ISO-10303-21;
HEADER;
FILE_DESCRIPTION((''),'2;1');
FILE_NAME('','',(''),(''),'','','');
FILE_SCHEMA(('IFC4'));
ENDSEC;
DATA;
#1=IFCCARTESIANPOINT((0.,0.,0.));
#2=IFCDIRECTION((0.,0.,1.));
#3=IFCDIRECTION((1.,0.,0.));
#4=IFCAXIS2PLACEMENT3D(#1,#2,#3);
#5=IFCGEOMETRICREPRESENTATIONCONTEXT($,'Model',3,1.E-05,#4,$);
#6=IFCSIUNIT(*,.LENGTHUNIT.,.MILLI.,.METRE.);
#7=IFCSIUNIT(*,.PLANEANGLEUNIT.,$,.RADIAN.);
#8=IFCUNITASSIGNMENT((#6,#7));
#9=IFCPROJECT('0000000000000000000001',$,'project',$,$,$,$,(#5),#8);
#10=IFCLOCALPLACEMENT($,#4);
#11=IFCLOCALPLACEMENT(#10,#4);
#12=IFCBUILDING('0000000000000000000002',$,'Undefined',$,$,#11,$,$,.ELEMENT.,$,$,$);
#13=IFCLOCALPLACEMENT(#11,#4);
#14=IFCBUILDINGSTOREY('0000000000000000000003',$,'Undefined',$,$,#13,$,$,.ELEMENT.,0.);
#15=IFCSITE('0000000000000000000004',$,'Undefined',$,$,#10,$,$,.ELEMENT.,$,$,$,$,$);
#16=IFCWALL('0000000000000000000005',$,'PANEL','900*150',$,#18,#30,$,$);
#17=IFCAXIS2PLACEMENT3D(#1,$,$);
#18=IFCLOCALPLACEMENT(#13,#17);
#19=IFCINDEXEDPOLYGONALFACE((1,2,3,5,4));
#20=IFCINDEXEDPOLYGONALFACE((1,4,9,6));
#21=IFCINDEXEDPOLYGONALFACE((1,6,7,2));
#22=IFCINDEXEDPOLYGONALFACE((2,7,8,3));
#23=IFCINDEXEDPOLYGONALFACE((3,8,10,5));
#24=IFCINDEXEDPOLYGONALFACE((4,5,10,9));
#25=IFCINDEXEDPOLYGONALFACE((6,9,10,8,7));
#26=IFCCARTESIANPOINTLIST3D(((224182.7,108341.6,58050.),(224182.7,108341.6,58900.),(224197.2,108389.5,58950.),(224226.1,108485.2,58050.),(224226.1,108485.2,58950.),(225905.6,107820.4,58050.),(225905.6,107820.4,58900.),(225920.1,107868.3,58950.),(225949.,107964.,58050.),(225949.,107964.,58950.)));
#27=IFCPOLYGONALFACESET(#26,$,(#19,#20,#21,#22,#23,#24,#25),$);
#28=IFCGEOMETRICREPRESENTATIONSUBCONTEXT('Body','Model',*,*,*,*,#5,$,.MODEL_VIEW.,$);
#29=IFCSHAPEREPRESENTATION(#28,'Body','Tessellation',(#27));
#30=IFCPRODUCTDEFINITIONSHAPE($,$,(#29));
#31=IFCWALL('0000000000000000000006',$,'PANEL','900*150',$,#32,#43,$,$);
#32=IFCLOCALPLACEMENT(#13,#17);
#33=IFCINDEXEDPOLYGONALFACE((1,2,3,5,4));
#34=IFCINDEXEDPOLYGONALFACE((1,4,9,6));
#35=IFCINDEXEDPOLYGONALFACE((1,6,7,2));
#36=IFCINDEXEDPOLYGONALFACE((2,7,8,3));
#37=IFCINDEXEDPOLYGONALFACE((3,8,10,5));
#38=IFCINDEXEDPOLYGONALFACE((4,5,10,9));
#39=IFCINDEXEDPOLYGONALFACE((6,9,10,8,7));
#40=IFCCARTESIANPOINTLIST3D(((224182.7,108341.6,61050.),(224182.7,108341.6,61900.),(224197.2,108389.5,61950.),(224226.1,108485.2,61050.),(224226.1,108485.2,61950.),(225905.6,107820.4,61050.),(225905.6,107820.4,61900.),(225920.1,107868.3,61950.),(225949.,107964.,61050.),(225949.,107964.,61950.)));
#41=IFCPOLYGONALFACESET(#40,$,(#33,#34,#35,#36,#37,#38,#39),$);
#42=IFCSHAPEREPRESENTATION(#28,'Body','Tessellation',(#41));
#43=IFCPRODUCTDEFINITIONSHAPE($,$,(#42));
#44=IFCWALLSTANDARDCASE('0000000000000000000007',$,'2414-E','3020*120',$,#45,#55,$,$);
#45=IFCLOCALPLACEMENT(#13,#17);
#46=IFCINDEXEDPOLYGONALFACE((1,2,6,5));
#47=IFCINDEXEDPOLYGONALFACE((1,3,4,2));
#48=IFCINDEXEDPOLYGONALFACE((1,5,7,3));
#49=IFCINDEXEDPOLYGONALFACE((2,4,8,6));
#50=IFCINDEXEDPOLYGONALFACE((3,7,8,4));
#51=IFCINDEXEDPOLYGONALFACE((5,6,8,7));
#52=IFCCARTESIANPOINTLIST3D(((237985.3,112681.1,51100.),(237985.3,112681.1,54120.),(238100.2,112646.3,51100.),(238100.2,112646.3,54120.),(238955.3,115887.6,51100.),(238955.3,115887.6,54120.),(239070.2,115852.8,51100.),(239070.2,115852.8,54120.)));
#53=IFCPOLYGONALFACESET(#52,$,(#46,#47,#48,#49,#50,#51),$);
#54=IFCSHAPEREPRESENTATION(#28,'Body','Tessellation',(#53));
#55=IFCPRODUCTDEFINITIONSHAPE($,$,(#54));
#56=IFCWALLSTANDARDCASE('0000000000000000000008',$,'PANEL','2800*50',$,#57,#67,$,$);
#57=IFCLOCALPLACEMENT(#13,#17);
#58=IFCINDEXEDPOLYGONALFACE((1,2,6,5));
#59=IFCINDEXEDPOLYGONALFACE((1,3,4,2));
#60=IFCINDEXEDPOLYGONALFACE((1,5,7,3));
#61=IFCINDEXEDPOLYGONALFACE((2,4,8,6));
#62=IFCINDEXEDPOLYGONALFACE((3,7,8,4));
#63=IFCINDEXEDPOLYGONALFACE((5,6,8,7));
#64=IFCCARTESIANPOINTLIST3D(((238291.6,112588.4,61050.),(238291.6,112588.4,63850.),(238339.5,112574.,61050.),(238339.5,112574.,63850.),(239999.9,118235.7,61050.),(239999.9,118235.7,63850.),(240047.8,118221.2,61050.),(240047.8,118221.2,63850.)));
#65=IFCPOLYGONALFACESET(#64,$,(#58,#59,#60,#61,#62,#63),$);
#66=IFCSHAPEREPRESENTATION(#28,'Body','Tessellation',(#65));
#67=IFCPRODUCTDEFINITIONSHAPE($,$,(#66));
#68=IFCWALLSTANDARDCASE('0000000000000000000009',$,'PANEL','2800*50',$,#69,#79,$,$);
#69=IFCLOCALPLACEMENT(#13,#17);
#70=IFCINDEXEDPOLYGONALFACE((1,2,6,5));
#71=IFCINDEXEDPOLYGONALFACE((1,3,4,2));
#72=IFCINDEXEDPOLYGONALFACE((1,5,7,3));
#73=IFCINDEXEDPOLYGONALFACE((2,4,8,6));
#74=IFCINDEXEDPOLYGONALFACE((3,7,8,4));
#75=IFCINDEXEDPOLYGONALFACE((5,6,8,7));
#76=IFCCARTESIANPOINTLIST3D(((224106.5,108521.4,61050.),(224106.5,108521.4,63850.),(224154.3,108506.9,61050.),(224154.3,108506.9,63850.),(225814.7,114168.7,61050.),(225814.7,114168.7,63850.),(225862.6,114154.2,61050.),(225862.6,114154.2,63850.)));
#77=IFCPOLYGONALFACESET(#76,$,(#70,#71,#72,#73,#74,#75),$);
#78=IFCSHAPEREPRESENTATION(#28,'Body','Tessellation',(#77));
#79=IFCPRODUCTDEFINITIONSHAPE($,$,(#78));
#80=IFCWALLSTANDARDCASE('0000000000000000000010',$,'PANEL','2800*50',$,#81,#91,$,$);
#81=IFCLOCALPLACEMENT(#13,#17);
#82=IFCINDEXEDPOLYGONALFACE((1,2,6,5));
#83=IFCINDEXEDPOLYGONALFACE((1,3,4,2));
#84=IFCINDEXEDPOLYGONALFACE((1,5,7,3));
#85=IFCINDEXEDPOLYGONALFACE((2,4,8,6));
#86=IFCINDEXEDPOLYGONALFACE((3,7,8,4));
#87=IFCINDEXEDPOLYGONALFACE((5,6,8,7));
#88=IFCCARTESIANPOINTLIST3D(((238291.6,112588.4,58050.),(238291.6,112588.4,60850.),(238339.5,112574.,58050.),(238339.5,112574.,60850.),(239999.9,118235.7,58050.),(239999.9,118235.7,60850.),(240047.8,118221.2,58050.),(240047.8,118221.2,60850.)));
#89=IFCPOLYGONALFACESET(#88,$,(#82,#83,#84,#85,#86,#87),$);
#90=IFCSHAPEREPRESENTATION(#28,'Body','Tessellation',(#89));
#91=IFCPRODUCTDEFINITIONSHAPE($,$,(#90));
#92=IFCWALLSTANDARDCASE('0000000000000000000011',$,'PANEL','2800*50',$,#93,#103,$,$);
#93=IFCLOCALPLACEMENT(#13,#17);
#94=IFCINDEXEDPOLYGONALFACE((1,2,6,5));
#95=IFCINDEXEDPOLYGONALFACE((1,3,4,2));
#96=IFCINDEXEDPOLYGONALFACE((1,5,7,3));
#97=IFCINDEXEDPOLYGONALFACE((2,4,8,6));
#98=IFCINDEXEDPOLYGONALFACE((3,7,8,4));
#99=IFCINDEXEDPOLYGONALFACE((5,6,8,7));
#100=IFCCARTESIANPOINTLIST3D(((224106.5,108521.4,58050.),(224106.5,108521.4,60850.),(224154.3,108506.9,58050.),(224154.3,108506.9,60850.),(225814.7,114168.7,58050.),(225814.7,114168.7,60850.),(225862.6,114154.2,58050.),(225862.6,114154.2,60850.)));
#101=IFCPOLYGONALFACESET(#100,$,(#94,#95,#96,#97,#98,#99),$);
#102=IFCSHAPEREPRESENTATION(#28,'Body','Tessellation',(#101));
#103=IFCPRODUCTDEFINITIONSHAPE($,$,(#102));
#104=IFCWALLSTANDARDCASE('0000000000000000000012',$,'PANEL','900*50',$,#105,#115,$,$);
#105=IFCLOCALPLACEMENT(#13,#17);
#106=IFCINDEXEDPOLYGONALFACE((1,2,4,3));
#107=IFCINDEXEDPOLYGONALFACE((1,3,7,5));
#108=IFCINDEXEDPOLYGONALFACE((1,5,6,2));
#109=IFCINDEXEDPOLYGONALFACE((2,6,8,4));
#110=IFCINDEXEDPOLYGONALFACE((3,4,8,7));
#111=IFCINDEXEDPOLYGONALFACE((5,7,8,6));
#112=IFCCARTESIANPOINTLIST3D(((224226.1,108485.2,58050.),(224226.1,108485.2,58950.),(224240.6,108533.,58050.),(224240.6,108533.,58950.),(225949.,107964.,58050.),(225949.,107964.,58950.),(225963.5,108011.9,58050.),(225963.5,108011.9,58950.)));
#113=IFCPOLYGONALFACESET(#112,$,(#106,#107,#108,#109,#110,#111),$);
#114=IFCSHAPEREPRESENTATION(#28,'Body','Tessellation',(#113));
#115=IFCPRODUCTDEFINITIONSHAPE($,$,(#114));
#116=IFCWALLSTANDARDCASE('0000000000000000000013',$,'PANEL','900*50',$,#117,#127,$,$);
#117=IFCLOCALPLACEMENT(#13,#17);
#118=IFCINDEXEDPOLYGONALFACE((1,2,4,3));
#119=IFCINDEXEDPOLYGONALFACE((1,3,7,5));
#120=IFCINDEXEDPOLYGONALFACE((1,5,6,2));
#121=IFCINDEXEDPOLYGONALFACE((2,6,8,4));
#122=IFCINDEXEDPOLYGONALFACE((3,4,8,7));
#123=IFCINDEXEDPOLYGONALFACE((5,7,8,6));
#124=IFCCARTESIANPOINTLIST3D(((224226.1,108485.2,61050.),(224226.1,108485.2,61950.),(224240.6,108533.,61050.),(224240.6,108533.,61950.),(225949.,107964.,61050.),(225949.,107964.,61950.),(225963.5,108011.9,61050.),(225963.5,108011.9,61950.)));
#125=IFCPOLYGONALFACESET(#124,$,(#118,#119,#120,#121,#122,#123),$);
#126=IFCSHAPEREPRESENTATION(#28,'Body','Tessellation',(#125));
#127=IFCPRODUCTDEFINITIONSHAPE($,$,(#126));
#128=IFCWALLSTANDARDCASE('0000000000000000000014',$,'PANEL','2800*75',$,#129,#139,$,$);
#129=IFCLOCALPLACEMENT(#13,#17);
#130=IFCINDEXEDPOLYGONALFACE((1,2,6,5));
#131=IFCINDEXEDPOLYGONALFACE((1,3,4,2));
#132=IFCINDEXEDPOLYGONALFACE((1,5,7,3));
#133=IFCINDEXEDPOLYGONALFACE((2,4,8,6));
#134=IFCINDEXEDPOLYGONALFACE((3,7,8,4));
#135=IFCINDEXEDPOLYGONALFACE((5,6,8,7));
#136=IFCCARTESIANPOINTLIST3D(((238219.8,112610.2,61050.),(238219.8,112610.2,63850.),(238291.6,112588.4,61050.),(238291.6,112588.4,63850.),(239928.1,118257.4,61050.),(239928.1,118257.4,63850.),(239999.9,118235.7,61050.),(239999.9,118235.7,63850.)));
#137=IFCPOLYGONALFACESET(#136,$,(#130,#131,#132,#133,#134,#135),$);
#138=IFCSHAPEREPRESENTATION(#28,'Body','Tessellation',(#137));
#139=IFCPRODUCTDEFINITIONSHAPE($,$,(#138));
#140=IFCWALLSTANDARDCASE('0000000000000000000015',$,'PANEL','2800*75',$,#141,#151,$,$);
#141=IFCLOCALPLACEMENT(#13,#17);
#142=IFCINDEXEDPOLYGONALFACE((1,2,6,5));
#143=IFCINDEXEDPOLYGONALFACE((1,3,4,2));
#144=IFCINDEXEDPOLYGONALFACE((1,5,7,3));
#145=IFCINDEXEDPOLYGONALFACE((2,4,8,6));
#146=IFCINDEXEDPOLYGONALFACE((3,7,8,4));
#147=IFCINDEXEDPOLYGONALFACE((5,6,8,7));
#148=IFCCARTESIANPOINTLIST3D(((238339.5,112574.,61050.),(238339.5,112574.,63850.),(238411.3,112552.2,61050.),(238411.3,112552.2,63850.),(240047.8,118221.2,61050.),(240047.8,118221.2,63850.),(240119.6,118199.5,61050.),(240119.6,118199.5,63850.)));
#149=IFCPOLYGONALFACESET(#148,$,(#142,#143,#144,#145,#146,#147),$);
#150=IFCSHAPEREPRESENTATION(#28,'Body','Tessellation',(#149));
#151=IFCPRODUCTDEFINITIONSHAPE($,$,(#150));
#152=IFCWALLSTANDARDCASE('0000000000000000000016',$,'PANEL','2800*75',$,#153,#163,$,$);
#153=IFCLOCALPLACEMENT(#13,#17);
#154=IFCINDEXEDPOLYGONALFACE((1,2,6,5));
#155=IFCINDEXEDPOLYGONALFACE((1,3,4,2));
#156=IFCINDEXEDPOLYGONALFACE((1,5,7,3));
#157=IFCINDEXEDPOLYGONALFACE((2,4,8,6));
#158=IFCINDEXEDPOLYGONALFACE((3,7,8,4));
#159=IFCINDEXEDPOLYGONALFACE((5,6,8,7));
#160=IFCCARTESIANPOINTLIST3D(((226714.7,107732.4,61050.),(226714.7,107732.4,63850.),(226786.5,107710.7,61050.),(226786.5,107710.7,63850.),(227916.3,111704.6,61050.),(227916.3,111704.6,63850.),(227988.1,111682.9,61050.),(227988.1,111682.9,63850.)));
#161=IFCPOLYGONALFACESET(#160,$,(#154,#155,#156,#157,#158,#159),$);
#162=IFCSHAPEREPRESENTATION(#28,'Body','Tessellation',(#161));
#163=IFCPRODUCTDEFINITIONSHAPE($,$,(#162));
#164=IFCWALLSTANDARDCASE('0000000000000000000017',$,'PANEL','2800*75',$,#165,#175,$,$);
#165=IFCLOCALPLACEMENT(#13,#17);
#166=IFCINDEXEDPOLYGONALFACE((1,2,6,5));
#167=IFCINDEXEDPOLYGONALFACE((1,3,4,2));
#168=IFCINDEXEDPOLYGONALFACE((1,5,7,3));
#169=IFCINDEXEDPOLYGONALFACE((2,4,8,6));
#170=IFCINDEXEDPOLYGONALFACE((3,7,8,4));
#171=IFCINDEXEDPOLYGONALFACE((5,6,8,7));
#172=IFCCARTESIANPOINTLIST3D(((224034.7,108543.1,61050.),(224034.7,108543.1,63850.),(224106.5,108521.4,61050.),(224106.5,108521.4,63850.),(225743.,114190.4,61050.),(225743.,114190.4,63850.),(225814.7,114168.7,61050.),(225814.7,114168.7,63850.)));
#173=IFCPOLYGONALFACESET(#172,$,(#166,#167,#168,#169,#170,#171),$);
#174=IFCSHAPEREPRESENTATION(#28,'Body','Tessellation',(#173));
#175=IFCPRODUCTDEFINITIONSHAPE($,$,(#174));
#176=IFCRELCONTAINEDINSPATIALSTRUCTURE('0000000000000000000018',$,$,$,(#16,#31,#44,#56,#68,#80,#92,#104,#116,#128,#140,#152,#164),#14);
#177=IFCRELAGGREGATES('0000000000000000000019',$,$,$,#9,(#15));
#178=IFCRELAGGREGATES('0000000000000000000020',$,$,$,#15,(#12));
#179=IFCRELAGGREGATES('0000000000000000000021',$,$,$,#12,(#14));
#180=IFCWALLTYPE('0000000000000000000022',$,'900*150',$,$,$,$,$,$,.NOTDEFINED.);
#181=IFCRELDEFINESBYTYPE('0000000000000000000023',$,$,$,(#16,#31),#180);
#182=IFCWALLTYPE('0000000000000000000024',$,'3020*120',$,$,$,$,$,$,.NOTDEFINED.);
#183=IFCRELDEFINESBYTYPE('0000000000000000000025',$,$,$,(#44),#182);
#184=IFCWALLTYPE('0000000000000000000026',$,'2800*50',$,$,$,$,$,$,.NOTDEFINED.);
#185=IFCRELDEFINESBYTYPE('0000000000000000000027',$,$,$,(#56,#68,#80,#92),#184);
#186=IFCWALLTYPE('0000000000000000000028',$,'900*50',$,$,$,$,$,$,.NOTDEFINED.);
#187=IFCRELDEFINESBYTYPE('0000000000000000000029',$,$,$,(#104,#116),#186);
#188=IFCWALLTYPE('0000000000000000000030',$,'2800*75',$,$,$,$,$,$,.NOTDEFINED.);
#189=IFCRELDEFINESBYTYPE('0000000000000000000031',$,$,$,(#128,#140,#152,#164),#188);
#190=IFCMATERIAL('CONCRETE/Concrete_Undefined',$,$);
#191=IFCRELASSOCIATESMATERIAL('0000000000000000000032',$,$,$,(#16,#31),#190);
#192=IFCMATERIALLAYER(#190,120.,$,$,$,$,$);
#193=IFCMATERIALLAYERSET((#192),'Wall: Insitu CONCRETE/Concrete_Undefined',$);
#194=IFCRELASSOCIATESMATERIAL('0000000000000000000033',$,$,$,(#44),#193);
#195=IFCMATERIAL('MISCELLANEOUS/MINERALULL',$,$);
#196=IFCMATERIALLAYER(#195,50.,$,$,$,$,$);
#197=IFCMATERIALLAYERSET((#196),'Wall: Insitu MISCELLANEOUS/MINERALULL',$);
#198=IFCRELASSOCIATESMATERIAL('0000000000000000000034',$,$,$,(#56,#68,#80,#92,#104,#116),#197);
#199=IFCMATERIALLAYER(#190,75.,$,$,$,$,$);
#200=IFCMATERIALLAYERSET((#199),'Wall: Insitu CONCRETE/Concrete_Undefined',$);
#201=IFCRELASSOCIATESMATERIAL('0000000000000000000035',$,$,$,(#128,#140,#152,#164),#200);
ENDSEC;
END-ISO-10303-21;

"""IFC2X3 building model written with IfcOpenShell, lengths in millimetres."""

from ifc_helpers import new_model, si_unit, frame, frame_2d, origin_with_axes, place, context, subcontext, project, spatial, rectangle, extrude, clip, halfspace, material, layer, layer_set, layer_usage, type_object, element, save


model = new_model("IFC2X3")

# Units and contexts
model_context = context("Model", 3, precision=1e-05, world=origin_with_axes())
body_context = subcontext(model_context, "Body", "Model", "MODEL_VIEW")
ifc_project = project(units=[si_unit("LENGTHUNIT", "METRE", prefix="MILLI"), si_unit("PLANEANGLEUNIT", "RADIAN")], contexts=[model_context])

# Site, building, storey
site_placement = place(None, origin_with_axes())
site = spatial("IfcSite", under=ifc_project, at=site_placement, Name="Undefined", CompositionType="ELEMENT")
building_placement = place(site_placement, origin_with_axes())
building = spatial("IfcBuilding", under=site, at=building_placement, Name="Undefined", CompositionType="ELEMENT")
storey_placement = place(building_placement, origin_with_axes())
storey = spatial("IfcBuildingStorey", under=building, at=storey_placement, Name="Undefined", CompositionType="ELEMENT", Elevation=0.0)

# Shared definitions
ifc_material_1 = material(Name="CONCRETE/Concrete_Undefined")

# Walls
wall_type_1 = type_object("IfcWallType", Name="900*150", PredefinedType="NOTDEFINED")
for number, where, z_axis, x_axis, name in (
    (1, (224204.4, 108413.4, 58050.0), (0.0, 0.0, 1.0), (0.957166, -0.289541, 0.0), "PANEL"),
    (2, (224204.4, 108413.4, 61050.0), (0.0, 0.0, 1.0), (0.957166, -0.289541, 0.0), "PANEL"),
):
    element("IfcWall", number, at=place(storey_placement, frame(where, z_axis=z_axis, x_axis=x_axis)), inside=storey, type_object=wall_type_1, material=ifc_material_1, Name=name, Description="900*150", context=body_context, shape_type="Clipping", body=[
        clip(extrude(rectangle(XDim=1800.0, YDim=150.0, at=frame_2d((0.0, 900.0), x_axis=(0.0, -1.0))), frame((0.0, 0.0, 0.0), z_axis=(0.0, 0.0, 1.0), x_axis=(0.0, -1.0, 0.0)), (0.0, 0.0, 1.0), 900.0), halfspace(frame((2400.0, 75.0, 1000.0), z_axis=(0.000001, -0.707072, 0.707141), x_axis=(0.0, -0.707141, -0.707072)), False)),
    ])
ifc_layer_1 = layer(ifc_material_1, 120.0)
ifc_layer_set_1 = layer_set([ifc_layer_1], Name="Wall: Insitu CONCRETE/Concrete_Undefined")
ifc_layer_usage_1 = layer_usage(ifc_layer_set_1, "AXIS2", "POSITIVE", -60.0)
wall_type_2 = type_object("IfcWallType", Name="3020*120", PredefinedType="NOTDEFINED")
wall_1_placement = place(storey_placement, frame((238042.8, 112663.7, 51100.0), z_axis=(0.0, 0.0, 1.0), x_axis=(0.289539, 0.957166, 0.0)))
element("IfcWallStandardCase", 3, at=wall_1_placement, inside=storey, type_object=wall_type_2, material=ifc_layer_usage_1, Name="2414-E", Description="3020*120", context=body_context, shape_type="SweptSolid", body=[
    extrude(rectangle(XDim=3350.0, YDim=120.0, at=frame_2d((0.0, 1675.0), x_axis=(0.0, -1.0))), frame((0.0, 0.0, 0.0), z_axis=(0.0, 0.0, 1.0), x_axis=(0.0, -1.0, 0.0)), (0.0, 0.0, 1.0), 3020.0),
])
ifc_material_2 = material(Name="MISCELLANEOUS/MINERALULL")
ifc_layer_2 = layer(ifc_material_2, 50.0)
ifc_layer_set_2 = layer_set([ifc_layer_2], Name="Wall: Insitu MISCELLANEOUS/MINERALULL")
ifc_layer_usage_2 = layer_usage(ifc_layer_set_2, "AXIS2", "POSITIVE", -25.0)
wall_type_3 = type_object("IfcWallType", Name="2800*50", PredefinedType="NOTDEFINED")
wall_2_placement = place(storey_placement, frame((238315.6, 112581.2, 61050.0), z_axis=(0.0, 0.0, 1.0), x_axis=(0.289537, 0.957167, 0.0)))
element("IfcWallStandardCase", 4, at=wall_2_placement, inside=storey, type_object=wall_type_3, material=ifc_layer_usage_2, Name="PANEL", Description="2800*50", context=body_context, shape_type="SweptSolid", body=[
    extrude(rectangle(XDim=5900.0, YDim=50.0, at=frame_2d((0.0, 2950.0), x_axis=(0.0, -1.0))), frame((0.0, 0.0, 0.0), z_axis=(0.0, 0.0, 1.0), x_axis=(0.0, -1.0, 0.0)), (0.0, 0.0, 1.0), 2800.0),
])
ifc_layer_usage_3 = layer_usage(ifc_layer_set_2, "AXIS2", "POSITIVE", -25.0)
wall_3_placement = place(storey_placement, frame((224130.4, 108514.1, 61050.0), z_axis=(0.0, 0.0, 1.0), x_axis=(0.289538, 0.957166, 0.0)))
element("IfcWallStandardCase", 5, at=wall_3_placement, inside=storey, type_object=wall_type_3, material=ifc_layer_usage_3, Name="PANEL", Description="2800*50", context=body_context, shape_type="SweptSolid", body=[
    extrude(rectangle(XDim=5900.0, YDim=50.0, at=frame_2d((0.0, 2950.0), x_axis=(0.0, -1.0))), frame((0.0, 0.0, 0.0), z_axis=(0.0, 0.0, 1.0), x_axis=(0.0, -1.0, 0.0)), (0.0, 0.0, 1.0), 2800.0),
])
ifc_layer_usage_4 = layer_usage(ifc_layer_set_2, "AXIS2", "POSITIVE", -25.0)
wall_4_placement = place(storey_placement, frame((238315.6, 112581.2, 58050.0), z_axis=(0.0, 0.0, 1.0), x_axis=(0.289537, 0.957167, 0.0)))
element("IfcWallStandardCase", 6, at=wall_4_placement, inside=storey, type_object=wall_type_3, material=ifc_layer_usage_4, Name="PANEL", Description="2800*50", context=body_context, shape_type="SweptSolid", body=[
    extrude(rectangle(XDim=5900.0, YDim=50.0, at=frame_2d((0.0, 2950.0), x_axis=(0.0, -1.0))), frame((0.0, 0.0, 0.0), z_axis=(0.0, 0.0, 1.0), x_axis=(0.0, -1.0, 0.0)), (0.0, 0.0, 1.0), 2800.0),
])
ifc_layer_usage_5 = layer_usage(ifc_layer_set_2, "AXIS2", "POSITIVE", -25.0)
wall_5_placement = place(storey_placement, frame((224130.4, 108514.1, 58050.0), z_axis=(0.0, 0.0, 1.0), x_axis=(0.289538, 0.957166, 0.0)))
element("IfcWallStandardCase", 7, at=wall_5_placement, inside=storey, type_object=wall_type_3, material=ifc_layer_usage_5, Name="PANEL", Description="2800*50", context=body_context, shape_type="SweptSolid", body=[
    extrude(rectangle(XDim=5900.0, YDim=50.0, at=frame_2d((0.0, 2950.0), x_axis=(0.0, -1.0))), frame((0.0, 0.0, 0.0), z_axis=(0.0, 0.0, 1.0), x_axis=(0.0, -1.0, 0.0)), (0.0, 0.0, 1.0), 2800.0),
])
ifc_layer_usage_6 = layer_usage(ifc_layer_set_2, "AXIS2", "POSITIVE", -25.0)
wall_type_4 = type_object("IfcWallType", Name="900*50", PredefinedType="NOTDEFINED")
wall_6_placement = place(storey_placement, frame((224233.4, 108509.1, 58050.0), z_axis=(0.0, 0.0, 1.0), x_axis=(0.957166, -0.289541, 0.0)))
element("IfcWallStandardCase", 8, at=wall_6_placement, inside=storey, type_object=wall_type_4, material=ifc_layer_usage_6, Name="PANEL", Description="900*50", context=body_context, shape_type="SweptSolid", body=[
    extrude(rectangle(XDim=1800.0, YDim=50.0, at=frame_2d((0.0, 900.0), x_axis=(0.0, -1.0))), frame((0.0, 0.0, 0.0), z_axis=(0.0, 0.0, 1.0), x_axis=(0.0, -1.0, 0.0)), (0.0, 0.0, 1.0), 900.0),
])
ifc_layer_usage_7 = layer_usage(ifc_layer_set_2, "AXIS2", "POSITIVE", -25.0)
wall_7_placement = place(storey_placement, frame((224233.4, 108509.1, 61050.0), z_axis=(0.0, 0.0, 1.0), x_axis=(0.957166, -0.289541, 0.0)))
element("IfcWallStandardCase", 9, at=wall_7_placement, inside=storey, type_object=wall_type_4, material=ifc_layer_usage_7, Name="PANEL", Description="900*50", context=body_context, shape_type="SweptSolid", body=[
    extrude(rectangle(XDim=1800.0, YDim=50.0, at=frame_2d((0.0, 900.0), x_axis=(0.0, -1.0))), frame((0.0, 0.0, 0.0), z_axis=(0.0, 0.0, 1.0), x_axis=(0.0, -1.0, 0.0)), (0.0, 0.0, 1.0), 900.0),
])
ifc_layer_3 = layer(ifc_material_1, 75.0)
ifc_layer_set_3 = layer_set([ifc_layer_3], Name="Wall: Insitu CONCRETE/Concrete_Undefined")
ifc_layer_usage_8 = layer_usage(ifc_layer_set_3, "AXIS2", "POSITIVE", -37.5)
wall_type_5 = type_object("IfcWallType", Name="2800*75", PredefinedType="NOTDEFINED")
wall_8_placement = place(storey_placement, frame((238255.7, 112599.3, 61050.0), z_axis=(0.0, 0.0, 1.0), x_axis=(0.289537, 0.957167, 0.0)))
element("IfcWallStandardCase", 10, at=wall_8_placement, inside=storey, type_object=wall_type_5, material=ifc_layer_usage_8, Name="PANEL", Description="2800*75", context=body_context, shape_type="SweptSolid", body=[
    extrude(rectangle(XDim=5900.0, YDim=75.0, at=frame_2d((0.0, 2950.0), x_axis=(0.0, -1.0))), frame((0.0, 0.0, 0.0), z_axis=(0.0, 0.0, 1.0), x_axis=(0.0, -1.0, 0.0)), (0.0, 0.0, 1.0), 2800.0),
])
ifc_layer_usage_9 = layer_usage(ifc_layer_set_3, "AXIS2", "POSITIVE", -37.5)
wall_9_placement = place(storey_placement, frame((238375.4, 112563.1, 61050.0), z_axis=(0.0, 0.0, 1.0), x_axis=(0.289537, 0.957167, 0.0)))
element("IfcWallStandardCase", 11, at=wall_9_placement, inside=storey, type_object=wall_type_5, material=ifc_layer_usage_9, Name="PANEL", Description="2800*75", context=body_context, shape_type="SweptSolid", body=[
    extrude(rectangle(XDim=5900.0, YDim=75.0, at=frame_2d((0.0, 2950.0), x_axis=(0.0, -1.0))), frame((0.0, 0.0, 0.0), z_axis=(0.0, 0.0, 1.0), x_axis=(0.0, -1.0, 0.0)), (0.0, 0.0, 1.0), 2800.0),
])
ifc_layer_usage_10 = layer_usage(ifc_layer_set_3, "AXIS2", "POSITIVE", -37.5)
wall_10_placement = place(storey_placement, frame((226750.6, 107721.5, 61050.0), z_axis=(0.0, 0.0, 1.0), x_axis=(0.289539, 0.957166, 0.0)))
element("IfcWallStandardCase", 12, at=wall_10_placement, inside=storey, type_object=wall_type_5, material=ifc_layer_usage_10, Name="PANEL", Description="2800*75", context=body_context, shape_type="SweptSolid", body=[
    extrude(rectangle(XDim=4150.0, YDim=75.0, at=frame_2d((0.0, 2075.0), x_axis=(0.0, -1.0))), frame((0.0, 0.0, 0.0), z_axis=(0.0, 0.0, 1.0), x_axis=(0.0, -1.0, 0.0)), (0.0, 0.0, 1.0), 2800.0),
])
ifc_layer_usage_11 = layer_usage(ifc_layer_set_3, "AXIS2", "POSITIVE", -37.5)
wall_11_placement = place(storey_placement, frame((224070.6, 108532.2, 61050.0), z_axis=(0.0, 0.0, 1.0), x_axis=(0.289538, 0.957166, 0.0)))
element("IfcWallStandardCase", 13, at=wall_11_placement, inside=storey, type_object=wall_type_5, material=ifc_layer_usage_11, Name="PANEL", Description="2800*75", context=body_context, shape_type="SweptSolid", body=[
    extrude(rectangle(XDim=5900.0, YDim=75.0, at=frame_2d((0.0, 2950.0), x_axis=(0.0, -1.0))), frame((0.0, 0.0, 0.0), z_axis=(0.0, 0.0, 1.0), x_axis=(0.0, -1.0, 0.0)), (0.0, 0.0, 1.0), 2800.0),
])

save(model, "model.ifc")
